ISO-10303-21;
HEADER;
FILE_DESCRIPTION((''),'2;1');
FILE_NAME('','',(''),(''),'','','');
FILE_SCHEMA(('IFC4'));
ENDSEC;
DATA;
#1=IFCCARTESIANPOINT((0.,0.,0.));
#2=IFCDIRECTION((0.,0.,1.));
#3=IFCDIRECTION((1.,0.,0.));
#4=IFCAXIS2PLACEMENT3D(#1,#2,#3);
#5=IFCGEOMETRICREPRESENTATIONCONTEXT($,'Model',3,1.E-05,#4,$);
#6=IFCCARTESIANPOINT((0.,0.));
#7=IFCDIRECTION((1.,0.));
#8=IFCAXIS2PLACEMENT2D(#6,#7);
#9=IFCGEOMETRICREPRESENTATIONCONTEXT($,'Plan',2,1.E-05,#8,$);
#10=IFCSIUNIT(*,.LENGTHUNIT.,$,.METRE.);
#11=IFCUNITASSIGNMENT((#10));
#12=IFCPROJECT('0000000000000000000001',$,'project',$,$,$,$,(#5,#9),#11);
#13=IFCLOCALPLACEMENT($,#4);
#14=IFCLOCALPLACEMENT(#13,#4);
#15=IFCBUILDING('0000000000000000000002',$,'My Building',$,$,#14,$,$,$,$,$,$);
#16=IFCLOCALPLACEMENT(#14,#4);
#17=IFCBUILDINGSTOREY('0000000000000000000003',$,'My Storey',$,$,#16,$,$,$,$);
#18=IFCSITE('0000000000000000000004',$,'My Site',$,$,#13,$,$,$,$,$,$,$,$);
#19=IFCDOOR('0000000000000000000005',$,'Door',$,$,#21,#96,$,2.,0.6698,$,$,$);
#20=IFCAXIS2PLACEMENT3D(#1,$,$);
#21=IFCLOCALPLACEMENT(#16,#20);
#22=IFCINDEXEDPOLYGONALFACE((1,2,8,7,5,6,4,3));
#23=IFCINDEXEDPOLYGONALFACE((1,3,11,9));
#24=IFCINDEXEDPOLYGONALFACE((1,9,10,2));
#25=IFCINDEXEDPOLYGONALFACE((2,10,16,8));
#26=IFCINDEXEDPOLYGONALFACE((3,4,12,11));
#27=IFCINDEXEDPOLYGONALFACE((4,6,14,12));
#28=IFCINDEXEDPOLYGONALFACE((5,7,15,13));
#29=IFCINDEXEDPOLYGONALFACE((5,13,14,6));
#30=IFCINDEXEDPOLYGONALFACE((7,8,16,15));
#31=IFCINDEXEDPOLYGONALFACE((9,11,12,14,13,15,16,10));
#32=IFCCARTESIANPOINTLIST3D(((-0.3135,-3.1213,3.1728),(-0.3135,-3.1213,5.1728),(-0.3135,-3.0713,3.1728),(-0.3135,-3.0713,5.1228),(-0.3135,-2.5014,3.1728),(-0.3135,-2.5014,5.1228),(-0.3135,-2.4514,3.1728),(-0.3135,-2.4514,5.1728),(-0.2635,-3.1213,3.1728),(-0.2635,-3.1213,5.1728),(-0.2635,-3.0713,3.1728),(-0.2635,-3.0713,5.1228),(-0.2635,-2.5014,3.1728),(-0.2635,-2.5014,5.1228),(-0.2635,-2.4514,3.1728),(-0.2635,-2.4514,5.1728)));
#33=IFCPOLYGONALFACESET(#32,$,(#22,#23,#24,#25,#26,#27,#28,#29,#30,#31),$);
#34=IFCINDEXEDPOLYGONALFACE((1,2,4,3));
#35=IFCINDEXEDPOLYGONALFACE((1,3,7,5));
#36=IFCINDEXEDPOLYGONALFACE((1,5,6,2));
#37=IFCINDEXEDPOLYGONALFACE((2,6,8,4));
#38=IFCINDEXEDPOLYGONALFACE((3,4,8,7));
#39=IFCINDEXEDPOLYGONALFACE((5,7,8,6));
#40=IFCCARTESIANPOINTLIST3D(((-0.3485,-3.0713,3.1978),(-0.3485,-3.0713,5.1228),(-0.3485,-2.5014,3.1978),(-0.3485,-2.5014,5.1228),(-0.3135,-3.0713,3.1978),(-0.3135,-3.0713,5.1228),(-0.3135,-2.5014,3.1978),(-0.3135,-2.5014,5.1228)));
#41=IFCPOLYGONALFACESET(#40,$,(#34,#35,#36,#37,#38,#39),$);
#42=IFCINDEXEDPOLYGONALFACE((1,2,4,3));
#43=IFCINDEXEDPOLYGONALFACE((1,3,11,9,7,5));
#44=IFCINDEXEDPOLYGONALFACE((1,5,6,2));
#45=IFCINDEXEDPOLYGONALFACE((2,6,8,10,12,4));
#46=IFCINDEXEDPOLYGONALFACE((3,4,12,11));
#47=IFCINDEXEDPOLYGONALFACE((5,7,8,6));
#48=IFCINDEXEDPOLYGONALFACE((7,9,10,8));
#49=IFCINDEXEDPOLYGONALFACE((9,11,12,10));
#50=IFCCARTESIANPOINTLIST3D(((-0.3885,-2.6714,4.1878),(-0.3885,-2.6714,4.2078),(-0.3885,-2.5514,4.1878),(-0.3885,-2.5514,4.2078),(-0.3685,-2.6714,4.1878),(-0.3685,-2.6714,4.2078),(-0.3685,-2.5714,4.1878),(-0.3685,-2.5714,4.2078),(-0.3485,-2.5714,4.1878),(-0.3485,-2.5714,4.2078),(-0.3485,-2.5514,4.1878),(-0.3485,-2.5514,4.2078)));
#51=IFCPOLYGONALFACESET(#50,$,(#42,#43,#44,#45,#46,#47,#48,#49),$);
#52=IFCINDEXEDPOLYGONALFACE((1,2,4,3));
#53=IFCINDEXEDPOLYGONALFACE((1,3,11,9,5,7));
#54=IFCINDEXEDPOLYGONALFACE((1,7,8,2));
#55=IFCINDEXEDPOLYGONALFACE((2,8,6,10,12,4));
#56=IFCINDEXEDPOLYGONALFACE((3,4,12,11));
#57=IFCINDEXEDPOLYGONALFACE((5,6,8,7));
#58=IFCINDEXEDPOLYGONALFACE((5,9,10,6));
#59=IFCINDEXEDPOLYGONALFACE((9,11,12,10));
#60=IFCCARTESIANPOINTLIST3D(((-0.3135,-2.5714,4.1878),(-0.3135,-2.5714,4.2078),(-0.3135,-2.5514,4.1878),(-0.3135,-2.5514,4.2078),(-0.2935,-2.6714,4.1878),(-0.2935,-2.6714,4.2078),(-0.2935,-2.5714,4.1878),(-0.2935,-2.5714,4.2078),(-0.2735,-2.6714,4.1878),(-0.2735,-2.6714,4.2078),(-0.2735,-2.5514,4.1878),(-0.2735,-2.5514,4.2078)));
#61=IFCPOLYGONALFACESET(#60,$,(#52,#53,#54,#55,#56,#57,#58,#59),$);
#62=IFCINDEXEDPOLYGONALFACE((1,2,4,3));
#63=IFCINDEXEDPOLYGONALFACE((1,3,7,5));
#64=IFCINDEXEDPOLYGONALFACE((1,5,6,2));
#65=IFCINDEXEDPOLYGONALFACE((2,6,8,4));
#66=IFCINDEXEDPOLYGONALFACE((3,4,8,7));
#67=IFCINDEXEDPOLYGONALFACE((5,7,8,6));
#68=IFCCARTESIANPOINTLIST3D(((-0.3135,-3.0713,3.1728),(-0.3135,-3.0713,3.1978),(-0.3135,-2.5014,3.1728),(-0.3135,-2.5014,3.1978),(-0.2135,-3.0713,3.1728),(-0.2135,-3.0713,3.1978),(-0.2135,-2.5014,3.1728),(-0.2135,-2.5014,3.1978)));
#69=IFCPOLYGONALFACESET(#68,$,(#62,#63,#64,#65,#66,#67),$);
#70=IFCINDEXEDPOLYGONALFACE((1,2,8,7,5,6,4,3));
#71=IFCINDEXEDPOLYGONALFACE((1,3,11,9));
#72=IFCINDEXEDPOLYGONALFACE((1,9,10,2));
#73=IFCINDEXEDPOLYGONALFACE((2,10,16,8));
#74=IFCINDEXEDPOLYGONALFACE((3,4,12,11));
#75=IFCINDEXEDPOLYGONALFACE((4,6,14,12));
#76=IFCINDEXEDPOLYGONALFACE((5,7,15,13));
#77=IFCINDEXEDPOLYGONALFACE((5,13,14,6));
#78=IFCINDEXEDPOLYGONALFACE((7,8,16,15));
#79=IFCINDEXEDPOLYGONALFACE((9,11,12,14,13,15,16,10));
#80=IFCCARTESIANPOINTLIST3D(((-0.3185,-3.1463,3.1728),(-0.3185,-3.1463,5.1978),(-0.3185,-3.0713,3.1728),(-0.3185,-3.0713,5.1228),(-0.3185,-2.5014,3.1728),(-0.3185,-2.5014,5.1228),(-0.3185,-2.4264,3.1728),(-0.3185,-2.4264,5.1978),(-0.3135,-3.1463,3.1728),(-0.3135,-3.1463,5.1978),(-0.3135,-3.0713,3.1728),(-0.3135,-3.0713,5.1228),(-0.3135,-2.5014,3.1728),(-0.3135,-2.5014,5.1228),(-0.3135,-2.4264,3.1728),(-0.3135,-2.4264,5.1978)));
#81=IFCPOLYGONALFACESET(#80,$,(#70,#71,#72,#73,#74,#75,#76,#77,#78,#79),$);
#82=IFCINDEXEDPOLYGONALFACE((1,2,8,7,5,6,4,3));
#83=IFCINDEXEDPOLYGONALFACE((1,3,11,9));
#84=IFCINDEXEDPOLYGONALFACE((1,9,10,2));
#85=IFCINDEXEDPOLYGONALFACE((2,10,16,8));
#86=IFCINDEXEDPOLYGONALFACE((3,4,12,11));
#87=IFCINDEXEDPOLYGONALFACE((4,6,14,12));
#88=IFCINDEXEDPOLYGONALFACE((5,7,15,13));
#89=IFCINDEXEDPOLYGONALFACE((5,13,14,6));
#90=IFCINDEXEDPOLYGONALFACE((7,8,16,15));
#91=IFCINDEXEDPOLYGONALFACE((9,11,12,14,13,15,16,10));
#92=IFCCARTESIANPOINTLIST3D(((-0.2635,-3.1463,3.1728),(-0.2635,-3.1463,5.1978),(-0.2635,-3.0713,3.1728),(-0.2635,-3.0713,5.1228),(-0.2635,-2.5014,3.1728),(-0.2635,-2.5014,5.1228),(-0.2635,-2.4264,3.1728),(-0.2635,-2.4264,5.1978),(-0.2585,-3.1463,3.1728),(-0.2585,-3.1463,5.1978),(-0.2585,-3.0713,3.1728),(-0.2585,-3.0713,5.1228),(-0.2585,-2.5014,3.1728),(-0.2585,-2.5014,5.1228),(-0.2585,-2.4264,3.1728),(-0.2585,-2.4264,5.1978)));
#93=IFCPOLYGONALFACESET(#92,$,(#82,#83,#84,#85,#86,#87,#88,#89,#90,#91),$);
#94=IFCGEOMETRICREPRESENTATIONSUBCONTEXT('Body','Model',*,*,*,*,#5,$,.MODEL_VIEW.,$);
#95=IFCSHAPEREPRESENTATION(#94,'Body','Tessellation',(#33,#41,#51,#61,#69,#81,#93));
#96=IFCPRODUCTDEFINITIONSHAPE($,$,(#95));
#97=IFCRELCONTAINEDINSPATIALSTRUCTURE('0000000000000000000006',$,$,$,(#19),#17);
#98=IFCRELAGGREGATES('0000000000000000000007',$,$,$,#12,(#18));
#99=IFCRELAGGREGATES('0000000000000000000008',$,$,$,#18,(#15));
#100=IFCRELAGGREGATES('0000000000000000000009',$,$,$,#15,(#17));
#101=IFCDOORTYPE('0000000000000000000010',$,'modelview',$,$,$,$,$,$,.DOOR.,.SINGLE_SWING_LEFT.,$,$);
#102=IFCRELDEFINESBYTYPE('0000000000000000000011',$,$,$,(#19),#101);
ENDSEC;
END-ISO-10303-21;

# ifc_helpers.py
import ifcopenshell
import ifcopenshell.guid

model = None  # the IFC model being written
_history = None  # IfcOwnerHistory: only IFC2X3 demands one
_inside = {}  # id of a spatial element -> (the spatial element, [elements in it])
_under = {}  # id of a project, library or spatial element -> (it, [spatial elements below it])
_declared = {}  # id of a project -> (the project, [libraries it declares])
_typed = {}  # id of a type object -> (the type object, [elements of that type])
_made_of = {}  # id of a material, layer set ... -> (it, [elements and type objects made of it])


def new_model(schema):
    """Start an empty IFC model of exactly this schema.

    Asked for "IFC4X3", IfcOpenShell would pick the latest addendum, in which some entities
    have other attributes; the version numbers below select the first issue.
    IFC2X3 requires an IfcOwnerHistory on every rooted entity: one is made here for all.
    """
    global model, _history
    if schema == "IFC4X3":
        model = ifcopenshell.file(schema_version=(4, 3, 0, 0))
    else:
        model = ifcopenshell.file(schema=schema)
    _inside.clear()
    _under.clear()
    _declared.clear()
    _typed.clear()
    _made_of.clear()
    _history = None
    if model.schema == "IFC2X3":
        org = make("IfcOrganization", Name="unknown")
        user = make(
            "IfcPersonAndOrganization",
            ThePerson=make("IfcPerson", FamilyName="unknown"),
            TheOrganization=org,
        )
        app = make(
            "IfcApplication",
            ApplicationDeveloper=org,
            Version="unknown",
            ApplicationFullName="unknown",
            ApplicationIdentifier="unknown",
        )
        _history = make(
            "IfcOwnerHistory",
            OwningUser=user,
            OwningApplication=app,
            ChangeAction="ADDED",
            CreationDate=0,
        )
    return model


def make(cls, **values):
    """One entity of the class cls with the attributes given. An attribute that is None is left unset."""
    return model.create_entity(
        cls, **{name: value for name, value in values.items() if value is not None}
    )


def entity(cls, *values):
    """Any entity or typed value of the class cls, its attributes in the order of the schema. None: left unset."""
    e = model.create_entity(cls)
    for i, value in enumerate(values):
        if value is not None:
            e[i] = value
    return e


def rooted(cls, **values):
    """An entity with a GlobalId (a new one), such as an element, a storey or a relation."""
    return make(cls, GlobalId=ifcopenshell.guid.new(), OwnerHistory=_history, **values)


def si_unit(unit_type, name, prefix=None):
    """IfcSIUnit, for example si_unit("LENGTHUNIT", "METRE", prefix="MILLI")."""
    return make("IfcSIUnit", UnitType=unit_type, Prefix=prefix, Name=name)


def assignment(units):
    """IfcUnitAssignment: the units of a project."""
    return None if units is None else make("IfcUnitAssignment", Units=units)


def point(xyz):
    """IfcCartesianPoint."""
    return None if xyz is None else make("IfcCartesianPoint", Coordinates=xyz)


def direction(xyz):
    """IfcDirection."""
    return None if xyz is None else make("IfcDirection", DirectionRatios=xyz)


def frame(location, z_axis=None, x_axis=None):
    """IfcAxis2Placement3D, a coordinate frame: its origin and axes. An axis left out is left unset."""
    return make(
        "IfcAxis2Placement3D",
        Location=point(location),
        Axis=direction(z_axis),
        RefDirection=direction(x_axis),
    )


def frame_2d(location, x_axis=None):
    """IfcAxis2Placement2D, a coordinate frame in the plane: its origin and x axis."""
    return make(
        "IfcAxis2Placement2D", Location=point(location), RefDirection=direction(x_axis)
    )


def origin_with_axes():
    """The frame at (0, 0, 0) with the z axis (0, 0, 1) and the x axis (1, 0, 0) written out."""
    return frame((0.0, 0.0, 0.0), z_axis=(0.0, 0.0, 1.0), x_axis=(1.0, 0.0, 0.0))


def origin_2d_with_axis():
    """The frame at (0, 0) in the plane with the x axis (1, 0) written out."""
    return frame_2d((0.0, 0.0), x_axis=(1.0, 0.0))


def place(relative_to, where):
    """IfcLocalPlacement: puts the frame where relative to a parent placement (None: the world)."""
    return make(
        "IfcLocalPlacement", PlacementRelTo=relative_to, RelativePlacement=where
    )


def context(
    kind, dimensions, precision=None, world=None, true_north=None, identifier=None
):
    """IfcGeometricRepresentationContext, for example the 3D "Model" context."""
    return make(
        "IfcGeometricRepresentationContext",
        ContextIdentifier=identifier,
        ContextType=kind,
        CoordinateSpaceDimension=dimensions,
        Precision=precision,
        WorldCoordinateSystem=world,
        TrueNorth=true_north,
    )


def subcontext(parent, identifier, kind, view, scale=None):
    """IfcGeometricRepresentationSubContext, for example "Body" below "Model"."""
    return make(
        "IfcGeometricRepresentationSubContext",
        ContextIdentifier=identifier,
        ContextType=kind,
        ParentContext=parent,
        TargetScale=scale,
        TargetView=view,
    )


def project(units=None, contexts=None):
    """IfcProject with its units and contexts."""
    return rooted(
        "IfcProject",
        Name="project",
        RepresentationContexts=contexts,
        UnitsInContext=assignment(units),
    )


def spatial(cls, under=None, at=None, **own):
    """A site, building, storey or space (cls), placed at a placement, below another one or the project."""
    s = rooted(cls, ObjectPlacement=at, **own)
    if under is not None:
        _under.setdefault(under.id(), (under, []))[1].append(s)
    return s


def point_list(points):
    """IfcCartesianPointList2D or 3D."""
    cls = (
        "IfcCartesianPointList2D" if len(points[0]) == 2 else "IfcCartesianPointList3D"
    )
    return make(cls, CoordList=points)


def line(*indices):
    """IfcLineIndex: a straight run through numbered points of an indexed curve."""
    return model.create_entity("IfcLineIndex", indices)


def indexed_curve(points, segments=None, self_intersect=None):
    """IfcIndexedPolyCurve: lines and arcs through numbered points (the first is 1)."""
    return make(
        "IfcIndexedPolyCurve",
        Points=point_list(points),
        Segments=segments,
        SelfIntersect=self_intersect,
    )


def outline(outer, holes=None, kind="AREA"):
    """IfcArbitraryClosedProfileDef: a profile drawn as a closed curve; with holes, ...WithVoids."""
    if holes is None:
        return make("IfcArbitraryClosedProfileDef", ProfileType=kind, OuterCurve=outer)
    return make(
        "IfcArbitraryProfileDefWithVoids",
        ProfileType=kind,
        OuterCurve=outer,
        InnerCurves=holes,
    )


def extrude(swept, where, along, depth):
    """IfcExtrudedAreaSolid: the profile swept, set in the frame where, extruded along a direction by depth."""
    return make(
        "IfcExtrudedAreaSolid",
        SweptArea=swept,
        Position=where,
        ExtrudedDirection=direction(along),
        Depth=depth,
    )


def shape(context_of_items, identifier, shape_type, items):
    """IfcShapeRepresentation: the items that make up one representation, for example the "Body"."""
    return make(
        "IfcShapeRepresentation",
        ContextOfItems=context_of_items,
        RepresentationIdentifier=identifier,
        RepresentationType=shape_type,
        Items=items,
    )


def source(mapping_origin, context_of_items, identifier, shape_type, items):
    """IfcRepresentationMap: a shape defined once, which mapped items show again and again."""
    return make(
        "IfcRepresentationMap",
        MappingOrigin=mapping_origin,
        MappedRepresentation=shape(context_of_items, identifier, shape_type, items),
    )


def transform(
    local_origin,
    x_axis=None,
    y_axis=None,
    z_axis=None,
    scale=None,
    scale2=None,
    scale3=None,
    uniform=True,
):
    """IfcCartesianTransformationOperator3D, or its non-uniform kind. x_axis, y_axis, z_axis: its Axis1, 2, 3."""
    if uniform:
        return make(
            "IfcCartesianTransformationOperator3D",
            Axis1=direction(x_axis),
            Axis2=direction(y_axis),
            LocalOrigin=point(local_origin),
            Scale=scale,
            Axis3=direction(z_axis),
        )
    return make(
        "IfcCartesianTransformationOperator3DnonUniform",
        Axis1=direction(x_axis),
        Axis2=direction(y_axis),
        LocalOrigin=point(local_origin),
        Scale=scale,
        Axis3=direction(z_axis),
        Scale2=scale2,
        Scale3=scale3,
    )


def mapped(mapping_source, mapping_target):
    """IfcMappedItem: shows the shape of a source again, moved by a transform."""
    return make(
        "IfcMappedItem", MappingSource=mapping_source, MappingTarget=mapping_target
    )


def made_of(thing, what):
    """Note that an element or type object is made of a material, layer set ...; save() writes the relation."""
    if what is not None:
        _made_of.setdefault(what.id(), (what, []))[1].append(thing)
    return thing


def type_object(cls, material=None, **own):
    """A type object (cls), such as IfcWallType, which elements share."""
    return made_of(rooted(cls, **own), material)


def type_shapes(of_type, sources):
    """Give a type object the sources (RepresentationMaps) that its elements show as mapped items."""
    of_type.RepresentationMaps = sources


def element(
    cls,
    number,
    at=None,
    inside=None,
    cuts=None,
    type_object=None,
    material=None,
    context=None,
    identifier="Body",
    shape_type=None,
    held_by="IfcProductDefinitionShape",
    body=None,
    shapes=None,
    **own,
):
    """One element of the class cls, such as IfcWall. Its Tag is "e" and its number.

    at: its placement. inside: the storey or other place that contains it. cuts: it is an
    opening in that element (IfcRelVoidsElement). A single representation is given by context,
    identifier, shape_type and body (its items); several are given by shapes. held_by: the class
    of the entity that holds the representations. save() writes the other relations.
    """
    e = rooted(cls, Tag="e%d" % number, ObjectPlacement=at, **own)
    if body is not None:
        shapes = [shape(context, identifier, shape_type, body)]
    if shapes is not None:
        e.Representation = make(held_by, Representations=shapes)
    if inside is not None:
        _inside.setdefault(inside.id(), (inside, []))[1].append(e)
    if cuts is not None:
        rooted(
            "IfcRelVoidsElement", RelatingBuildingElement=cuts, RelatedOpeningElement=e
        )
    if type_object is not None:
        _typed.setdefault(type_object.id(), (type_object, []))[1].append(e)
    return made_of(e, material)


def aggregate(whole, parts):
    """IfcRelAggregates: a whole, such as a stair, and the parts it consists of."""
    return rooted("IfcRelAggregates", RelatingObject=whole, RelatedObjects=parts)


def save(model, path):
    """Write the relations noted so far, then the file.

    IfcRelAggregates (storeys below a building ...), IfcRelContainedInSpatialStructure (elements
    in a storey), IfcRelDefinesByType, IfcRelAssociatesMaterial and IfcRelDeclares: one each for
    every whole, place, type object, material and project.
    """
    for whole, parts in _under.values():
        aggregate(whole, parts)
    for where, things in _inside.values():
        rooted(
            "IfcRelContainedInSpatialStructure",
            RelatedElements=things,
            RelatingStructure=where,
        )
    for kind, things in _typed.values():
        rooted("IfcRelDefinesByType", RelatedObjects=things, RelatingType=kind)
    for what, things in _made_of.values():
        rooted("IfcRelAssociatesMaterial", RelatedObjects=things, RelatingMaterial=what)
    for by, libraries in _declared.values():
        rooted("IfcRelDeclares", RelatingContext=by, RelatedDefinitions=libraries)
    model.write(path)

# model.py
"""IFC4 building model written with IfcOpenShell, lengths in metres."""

from ifc_helpers import new_model, entity, si_unit, frame, origin_with_axes, origin_2d_with_axis, place, context, subcontext, project, spatial, line, indexed_curve, outline, extrude, shape, source, transform, mapped, type_object, type_shapes, element, save


model = new_model("IFC4")

# Units and contexts
model_context = context("Model", 3, precision=1e-05, world=origin_with_axes())
plan_context = context("Plan", 2, precision=1e-05, world=origin_2d_with_axis())
body_context_1 = subcontext(model_context, "Body", "Model", "MODEL_VIEW")
body_context_2 = subcontext(plan_context, "Body", "Plan", "PLAN_VIEW")
ifc_project = project(units=[si_unit("LENGTHUNIT", "METRE")], contexts=[model_context, plan_context])

# Site, building, storey
site_placement = place(None, origin_with_axes())
site = spatial("IfcSite", under=ifc_project, at=site_placement, Name="My Site")
building_placement = place(site_placement, origin_with_axes())
building = spatial("IfcBuilding", under=site, at=building_placement, Name="My Building")
storey_placement = place(building_placement, origin_with_axes())
storey = spatial("IfcBuildingStorey", under=building, at=storey_placement, Name="My Storey")

# Shared definitions
door_type_1 = type_object("IfcDoorType", Name="modelview", OperationType="SINGLE_SWING_LEFT", PredefinedType="DOOR")
shared_shape_1 = source(origin_with_axes(), body_context_1, "Body", "SweptSolid", [
    extrude(outline(indexed_curve([(0.0, 0.0), (0.0, 2.0), (0.6698, 2.0), (0.6698, 0.0), (0.6198, 0.0), (0.6198, 1.95), (0.05, 1.95), (0.05, 0.0)], segments=[line(1, 2, 3, 4, 5, 6, 7, 8, 1)])), frame((0.0, 0.0, 0.0), z_axis=(0.0, -1.0, 0.0), x_axis=(1.0, 0.0, 0.0)), (0.0, 0.0, -1.0), 0.05),
    extrude(outline(indexed_curve([(0.0, 0.0), (0.5698, 0.0), (0.5698, 0.035), (0.0, 0.035)], segments=[line(1, 2, 3, 4, 1)])), frame((0.05, -0.035, 0.025), z_axis=(0.0, 0.0, 1.0), x_axis=(1.0, 0.0, 0.0)), (0.0, 0.0, 1.0), 1.925),
    extrude(outline(indexed_curve([(0.0, 0.0), (0.0, -0.04), (0.12, -0.04), (0.12, -0.02), (0.02, -0.02), (0.02, 0.0)], segments=[line(1, 2, 3, 4, 5, 6, 1)])), frame((0.1, -0.035, 1.015), z_axis=(0.0, 0.0, 1.0), x_axis=(1.0, 0.0, 0.0)), (0.0, 0.0, 1.0), 0.02),
    extrude(outline(indexed_curve([(0.0, 0.0), (0.0, 0.04), (0.12, 0.04), (0.12, 0.02), (0.02, 0.02), (0.02, 0.0)], segments=[line(1, 2, 3, 4, 5, 6, 1)])), frame((0.1, 0.0, 1.015), z_axis=(0.0, 0.0, 1.0), x_axis=(1.0, 0.0, 0.0)), (0.0, 0.0, 1.0), 0.02),
    extrude(outline(indexed_curve([(0.0, 0.0), (0.5698, 0.0), (0.5698, 0.1), (0.0, 0.1)], segments=[line(1, 2, 3, 4, 1)])), frame((0.05, 0.0, 0.0), z_axis=(0.0, 0.0, 1.0), x_axis=(1.0, 0.0, 0.0)), (0.0, 0.0, 1.0), 0.025),
    extrude(outline(indexed_curve([(0.0, 0.0), (0.0, 2.025), (0.7198, 2.025), (0.7198, 0.0), (0.6448, 0.0), (0.6448, 1.95), (0.075, 1.95), (0.075, 0.0)], segments=[line(1, 2, 3, 4, 5, 6, 7, 8, 1)])), frame((-0.025, -0.005, 0.0), z_axis=(0.0, -1.0, 0.0), x_axis=(1.0, 0.0, 0.0)), (0.0, 0.0, -1.0), 0.005),
    extrude(outline(indexed_curve([(0.0, 0.0), (0.0, 2.025), (0.7198, 2.025), (0.7198, 0.0), (0.6448, 0.0), (0.6448, 1.95), (0.075, 1.95), (0.075, 0.0)], segments=[line(1, 2, 3, 4, 5, 6, 7, 8, 1)])), frame((-0.025, 0.05, 0.0), z_axis=(0.0, -1.0, 0.0), x_axis=(1.0, 0.0, 0.0)), (0.0, 0.0, -1.0), 0.005),
])
shared_shape_2 = source(origin_with_axes(), body_context_2, "Body", "Curve2D", [
    entity("IfcIndexedPolyCurve", entity("IfcCartesianPointList2D", [[0.0, 0.0], [0.05, 0.0], [0.05, 0.05], [0.0, 0.05]]), [entity("IfcLineIndex", [1, 2, 3, 4, 1])]),
    entity("IfcIndexedPolyCurve", entity("IfcCartesianPointList2D", [[0.6698, 0.0], [0.6198, 0.0], [0.6198, 0.05], [0.6698, 0.05]]), [entity("IfcLineIndex", [1, 2, 3, 4, 1])]),
    entity("IfcIndexedPolyCurve", entity("IfcCartesianPointList2D", [[0.9047, -0.035], [0.3349, -0.035], [0.3349, 0.0], [0.9047, 0.0]]), [entity("IfcLineIndex", [1, 2, 3, 4, 1])]),
])
type_shapes(door_type_1, [shared_shape_1, shared_shape_2])

# Door
door_1_placement = place(storey_placement, frame((-0.3135, -2.4514, 3.1728), z_axis=(0.0, 0.0, 1.0), x_axis=(0.0, -1.0, 0.0)))
element("IfcDoor", 1, at=door_1_placement, inside=storey, type_object=door_type_1, Name="Door", OverallHeight=2.0, OverallWidth=0.6698, shapes=[
    shape(body_context_1, "Body", "MappedRepresentation", [mapped(shared_shape_1, transform((0.0, 0.0, 0.0), x_axis=(1.0, 0.0, 0.0), y_axis=(0.0, 1.0, 0.0), z_axis=(0.0, 0.0, 1.0), scale=1.0))]),
    shape(body_context_2, "Body", "MappedRepresentation", [mapped(shared_shape_2, transform((0.0, 0.0, 0.0), x_axis=(1.0, 0.0, 0.0), y_axis=(0.0, 1.0, 0.0), z_axis=(0.0, 0.0, 1.0), scale=1.0))]),
])

save(model, "model.ifc")
